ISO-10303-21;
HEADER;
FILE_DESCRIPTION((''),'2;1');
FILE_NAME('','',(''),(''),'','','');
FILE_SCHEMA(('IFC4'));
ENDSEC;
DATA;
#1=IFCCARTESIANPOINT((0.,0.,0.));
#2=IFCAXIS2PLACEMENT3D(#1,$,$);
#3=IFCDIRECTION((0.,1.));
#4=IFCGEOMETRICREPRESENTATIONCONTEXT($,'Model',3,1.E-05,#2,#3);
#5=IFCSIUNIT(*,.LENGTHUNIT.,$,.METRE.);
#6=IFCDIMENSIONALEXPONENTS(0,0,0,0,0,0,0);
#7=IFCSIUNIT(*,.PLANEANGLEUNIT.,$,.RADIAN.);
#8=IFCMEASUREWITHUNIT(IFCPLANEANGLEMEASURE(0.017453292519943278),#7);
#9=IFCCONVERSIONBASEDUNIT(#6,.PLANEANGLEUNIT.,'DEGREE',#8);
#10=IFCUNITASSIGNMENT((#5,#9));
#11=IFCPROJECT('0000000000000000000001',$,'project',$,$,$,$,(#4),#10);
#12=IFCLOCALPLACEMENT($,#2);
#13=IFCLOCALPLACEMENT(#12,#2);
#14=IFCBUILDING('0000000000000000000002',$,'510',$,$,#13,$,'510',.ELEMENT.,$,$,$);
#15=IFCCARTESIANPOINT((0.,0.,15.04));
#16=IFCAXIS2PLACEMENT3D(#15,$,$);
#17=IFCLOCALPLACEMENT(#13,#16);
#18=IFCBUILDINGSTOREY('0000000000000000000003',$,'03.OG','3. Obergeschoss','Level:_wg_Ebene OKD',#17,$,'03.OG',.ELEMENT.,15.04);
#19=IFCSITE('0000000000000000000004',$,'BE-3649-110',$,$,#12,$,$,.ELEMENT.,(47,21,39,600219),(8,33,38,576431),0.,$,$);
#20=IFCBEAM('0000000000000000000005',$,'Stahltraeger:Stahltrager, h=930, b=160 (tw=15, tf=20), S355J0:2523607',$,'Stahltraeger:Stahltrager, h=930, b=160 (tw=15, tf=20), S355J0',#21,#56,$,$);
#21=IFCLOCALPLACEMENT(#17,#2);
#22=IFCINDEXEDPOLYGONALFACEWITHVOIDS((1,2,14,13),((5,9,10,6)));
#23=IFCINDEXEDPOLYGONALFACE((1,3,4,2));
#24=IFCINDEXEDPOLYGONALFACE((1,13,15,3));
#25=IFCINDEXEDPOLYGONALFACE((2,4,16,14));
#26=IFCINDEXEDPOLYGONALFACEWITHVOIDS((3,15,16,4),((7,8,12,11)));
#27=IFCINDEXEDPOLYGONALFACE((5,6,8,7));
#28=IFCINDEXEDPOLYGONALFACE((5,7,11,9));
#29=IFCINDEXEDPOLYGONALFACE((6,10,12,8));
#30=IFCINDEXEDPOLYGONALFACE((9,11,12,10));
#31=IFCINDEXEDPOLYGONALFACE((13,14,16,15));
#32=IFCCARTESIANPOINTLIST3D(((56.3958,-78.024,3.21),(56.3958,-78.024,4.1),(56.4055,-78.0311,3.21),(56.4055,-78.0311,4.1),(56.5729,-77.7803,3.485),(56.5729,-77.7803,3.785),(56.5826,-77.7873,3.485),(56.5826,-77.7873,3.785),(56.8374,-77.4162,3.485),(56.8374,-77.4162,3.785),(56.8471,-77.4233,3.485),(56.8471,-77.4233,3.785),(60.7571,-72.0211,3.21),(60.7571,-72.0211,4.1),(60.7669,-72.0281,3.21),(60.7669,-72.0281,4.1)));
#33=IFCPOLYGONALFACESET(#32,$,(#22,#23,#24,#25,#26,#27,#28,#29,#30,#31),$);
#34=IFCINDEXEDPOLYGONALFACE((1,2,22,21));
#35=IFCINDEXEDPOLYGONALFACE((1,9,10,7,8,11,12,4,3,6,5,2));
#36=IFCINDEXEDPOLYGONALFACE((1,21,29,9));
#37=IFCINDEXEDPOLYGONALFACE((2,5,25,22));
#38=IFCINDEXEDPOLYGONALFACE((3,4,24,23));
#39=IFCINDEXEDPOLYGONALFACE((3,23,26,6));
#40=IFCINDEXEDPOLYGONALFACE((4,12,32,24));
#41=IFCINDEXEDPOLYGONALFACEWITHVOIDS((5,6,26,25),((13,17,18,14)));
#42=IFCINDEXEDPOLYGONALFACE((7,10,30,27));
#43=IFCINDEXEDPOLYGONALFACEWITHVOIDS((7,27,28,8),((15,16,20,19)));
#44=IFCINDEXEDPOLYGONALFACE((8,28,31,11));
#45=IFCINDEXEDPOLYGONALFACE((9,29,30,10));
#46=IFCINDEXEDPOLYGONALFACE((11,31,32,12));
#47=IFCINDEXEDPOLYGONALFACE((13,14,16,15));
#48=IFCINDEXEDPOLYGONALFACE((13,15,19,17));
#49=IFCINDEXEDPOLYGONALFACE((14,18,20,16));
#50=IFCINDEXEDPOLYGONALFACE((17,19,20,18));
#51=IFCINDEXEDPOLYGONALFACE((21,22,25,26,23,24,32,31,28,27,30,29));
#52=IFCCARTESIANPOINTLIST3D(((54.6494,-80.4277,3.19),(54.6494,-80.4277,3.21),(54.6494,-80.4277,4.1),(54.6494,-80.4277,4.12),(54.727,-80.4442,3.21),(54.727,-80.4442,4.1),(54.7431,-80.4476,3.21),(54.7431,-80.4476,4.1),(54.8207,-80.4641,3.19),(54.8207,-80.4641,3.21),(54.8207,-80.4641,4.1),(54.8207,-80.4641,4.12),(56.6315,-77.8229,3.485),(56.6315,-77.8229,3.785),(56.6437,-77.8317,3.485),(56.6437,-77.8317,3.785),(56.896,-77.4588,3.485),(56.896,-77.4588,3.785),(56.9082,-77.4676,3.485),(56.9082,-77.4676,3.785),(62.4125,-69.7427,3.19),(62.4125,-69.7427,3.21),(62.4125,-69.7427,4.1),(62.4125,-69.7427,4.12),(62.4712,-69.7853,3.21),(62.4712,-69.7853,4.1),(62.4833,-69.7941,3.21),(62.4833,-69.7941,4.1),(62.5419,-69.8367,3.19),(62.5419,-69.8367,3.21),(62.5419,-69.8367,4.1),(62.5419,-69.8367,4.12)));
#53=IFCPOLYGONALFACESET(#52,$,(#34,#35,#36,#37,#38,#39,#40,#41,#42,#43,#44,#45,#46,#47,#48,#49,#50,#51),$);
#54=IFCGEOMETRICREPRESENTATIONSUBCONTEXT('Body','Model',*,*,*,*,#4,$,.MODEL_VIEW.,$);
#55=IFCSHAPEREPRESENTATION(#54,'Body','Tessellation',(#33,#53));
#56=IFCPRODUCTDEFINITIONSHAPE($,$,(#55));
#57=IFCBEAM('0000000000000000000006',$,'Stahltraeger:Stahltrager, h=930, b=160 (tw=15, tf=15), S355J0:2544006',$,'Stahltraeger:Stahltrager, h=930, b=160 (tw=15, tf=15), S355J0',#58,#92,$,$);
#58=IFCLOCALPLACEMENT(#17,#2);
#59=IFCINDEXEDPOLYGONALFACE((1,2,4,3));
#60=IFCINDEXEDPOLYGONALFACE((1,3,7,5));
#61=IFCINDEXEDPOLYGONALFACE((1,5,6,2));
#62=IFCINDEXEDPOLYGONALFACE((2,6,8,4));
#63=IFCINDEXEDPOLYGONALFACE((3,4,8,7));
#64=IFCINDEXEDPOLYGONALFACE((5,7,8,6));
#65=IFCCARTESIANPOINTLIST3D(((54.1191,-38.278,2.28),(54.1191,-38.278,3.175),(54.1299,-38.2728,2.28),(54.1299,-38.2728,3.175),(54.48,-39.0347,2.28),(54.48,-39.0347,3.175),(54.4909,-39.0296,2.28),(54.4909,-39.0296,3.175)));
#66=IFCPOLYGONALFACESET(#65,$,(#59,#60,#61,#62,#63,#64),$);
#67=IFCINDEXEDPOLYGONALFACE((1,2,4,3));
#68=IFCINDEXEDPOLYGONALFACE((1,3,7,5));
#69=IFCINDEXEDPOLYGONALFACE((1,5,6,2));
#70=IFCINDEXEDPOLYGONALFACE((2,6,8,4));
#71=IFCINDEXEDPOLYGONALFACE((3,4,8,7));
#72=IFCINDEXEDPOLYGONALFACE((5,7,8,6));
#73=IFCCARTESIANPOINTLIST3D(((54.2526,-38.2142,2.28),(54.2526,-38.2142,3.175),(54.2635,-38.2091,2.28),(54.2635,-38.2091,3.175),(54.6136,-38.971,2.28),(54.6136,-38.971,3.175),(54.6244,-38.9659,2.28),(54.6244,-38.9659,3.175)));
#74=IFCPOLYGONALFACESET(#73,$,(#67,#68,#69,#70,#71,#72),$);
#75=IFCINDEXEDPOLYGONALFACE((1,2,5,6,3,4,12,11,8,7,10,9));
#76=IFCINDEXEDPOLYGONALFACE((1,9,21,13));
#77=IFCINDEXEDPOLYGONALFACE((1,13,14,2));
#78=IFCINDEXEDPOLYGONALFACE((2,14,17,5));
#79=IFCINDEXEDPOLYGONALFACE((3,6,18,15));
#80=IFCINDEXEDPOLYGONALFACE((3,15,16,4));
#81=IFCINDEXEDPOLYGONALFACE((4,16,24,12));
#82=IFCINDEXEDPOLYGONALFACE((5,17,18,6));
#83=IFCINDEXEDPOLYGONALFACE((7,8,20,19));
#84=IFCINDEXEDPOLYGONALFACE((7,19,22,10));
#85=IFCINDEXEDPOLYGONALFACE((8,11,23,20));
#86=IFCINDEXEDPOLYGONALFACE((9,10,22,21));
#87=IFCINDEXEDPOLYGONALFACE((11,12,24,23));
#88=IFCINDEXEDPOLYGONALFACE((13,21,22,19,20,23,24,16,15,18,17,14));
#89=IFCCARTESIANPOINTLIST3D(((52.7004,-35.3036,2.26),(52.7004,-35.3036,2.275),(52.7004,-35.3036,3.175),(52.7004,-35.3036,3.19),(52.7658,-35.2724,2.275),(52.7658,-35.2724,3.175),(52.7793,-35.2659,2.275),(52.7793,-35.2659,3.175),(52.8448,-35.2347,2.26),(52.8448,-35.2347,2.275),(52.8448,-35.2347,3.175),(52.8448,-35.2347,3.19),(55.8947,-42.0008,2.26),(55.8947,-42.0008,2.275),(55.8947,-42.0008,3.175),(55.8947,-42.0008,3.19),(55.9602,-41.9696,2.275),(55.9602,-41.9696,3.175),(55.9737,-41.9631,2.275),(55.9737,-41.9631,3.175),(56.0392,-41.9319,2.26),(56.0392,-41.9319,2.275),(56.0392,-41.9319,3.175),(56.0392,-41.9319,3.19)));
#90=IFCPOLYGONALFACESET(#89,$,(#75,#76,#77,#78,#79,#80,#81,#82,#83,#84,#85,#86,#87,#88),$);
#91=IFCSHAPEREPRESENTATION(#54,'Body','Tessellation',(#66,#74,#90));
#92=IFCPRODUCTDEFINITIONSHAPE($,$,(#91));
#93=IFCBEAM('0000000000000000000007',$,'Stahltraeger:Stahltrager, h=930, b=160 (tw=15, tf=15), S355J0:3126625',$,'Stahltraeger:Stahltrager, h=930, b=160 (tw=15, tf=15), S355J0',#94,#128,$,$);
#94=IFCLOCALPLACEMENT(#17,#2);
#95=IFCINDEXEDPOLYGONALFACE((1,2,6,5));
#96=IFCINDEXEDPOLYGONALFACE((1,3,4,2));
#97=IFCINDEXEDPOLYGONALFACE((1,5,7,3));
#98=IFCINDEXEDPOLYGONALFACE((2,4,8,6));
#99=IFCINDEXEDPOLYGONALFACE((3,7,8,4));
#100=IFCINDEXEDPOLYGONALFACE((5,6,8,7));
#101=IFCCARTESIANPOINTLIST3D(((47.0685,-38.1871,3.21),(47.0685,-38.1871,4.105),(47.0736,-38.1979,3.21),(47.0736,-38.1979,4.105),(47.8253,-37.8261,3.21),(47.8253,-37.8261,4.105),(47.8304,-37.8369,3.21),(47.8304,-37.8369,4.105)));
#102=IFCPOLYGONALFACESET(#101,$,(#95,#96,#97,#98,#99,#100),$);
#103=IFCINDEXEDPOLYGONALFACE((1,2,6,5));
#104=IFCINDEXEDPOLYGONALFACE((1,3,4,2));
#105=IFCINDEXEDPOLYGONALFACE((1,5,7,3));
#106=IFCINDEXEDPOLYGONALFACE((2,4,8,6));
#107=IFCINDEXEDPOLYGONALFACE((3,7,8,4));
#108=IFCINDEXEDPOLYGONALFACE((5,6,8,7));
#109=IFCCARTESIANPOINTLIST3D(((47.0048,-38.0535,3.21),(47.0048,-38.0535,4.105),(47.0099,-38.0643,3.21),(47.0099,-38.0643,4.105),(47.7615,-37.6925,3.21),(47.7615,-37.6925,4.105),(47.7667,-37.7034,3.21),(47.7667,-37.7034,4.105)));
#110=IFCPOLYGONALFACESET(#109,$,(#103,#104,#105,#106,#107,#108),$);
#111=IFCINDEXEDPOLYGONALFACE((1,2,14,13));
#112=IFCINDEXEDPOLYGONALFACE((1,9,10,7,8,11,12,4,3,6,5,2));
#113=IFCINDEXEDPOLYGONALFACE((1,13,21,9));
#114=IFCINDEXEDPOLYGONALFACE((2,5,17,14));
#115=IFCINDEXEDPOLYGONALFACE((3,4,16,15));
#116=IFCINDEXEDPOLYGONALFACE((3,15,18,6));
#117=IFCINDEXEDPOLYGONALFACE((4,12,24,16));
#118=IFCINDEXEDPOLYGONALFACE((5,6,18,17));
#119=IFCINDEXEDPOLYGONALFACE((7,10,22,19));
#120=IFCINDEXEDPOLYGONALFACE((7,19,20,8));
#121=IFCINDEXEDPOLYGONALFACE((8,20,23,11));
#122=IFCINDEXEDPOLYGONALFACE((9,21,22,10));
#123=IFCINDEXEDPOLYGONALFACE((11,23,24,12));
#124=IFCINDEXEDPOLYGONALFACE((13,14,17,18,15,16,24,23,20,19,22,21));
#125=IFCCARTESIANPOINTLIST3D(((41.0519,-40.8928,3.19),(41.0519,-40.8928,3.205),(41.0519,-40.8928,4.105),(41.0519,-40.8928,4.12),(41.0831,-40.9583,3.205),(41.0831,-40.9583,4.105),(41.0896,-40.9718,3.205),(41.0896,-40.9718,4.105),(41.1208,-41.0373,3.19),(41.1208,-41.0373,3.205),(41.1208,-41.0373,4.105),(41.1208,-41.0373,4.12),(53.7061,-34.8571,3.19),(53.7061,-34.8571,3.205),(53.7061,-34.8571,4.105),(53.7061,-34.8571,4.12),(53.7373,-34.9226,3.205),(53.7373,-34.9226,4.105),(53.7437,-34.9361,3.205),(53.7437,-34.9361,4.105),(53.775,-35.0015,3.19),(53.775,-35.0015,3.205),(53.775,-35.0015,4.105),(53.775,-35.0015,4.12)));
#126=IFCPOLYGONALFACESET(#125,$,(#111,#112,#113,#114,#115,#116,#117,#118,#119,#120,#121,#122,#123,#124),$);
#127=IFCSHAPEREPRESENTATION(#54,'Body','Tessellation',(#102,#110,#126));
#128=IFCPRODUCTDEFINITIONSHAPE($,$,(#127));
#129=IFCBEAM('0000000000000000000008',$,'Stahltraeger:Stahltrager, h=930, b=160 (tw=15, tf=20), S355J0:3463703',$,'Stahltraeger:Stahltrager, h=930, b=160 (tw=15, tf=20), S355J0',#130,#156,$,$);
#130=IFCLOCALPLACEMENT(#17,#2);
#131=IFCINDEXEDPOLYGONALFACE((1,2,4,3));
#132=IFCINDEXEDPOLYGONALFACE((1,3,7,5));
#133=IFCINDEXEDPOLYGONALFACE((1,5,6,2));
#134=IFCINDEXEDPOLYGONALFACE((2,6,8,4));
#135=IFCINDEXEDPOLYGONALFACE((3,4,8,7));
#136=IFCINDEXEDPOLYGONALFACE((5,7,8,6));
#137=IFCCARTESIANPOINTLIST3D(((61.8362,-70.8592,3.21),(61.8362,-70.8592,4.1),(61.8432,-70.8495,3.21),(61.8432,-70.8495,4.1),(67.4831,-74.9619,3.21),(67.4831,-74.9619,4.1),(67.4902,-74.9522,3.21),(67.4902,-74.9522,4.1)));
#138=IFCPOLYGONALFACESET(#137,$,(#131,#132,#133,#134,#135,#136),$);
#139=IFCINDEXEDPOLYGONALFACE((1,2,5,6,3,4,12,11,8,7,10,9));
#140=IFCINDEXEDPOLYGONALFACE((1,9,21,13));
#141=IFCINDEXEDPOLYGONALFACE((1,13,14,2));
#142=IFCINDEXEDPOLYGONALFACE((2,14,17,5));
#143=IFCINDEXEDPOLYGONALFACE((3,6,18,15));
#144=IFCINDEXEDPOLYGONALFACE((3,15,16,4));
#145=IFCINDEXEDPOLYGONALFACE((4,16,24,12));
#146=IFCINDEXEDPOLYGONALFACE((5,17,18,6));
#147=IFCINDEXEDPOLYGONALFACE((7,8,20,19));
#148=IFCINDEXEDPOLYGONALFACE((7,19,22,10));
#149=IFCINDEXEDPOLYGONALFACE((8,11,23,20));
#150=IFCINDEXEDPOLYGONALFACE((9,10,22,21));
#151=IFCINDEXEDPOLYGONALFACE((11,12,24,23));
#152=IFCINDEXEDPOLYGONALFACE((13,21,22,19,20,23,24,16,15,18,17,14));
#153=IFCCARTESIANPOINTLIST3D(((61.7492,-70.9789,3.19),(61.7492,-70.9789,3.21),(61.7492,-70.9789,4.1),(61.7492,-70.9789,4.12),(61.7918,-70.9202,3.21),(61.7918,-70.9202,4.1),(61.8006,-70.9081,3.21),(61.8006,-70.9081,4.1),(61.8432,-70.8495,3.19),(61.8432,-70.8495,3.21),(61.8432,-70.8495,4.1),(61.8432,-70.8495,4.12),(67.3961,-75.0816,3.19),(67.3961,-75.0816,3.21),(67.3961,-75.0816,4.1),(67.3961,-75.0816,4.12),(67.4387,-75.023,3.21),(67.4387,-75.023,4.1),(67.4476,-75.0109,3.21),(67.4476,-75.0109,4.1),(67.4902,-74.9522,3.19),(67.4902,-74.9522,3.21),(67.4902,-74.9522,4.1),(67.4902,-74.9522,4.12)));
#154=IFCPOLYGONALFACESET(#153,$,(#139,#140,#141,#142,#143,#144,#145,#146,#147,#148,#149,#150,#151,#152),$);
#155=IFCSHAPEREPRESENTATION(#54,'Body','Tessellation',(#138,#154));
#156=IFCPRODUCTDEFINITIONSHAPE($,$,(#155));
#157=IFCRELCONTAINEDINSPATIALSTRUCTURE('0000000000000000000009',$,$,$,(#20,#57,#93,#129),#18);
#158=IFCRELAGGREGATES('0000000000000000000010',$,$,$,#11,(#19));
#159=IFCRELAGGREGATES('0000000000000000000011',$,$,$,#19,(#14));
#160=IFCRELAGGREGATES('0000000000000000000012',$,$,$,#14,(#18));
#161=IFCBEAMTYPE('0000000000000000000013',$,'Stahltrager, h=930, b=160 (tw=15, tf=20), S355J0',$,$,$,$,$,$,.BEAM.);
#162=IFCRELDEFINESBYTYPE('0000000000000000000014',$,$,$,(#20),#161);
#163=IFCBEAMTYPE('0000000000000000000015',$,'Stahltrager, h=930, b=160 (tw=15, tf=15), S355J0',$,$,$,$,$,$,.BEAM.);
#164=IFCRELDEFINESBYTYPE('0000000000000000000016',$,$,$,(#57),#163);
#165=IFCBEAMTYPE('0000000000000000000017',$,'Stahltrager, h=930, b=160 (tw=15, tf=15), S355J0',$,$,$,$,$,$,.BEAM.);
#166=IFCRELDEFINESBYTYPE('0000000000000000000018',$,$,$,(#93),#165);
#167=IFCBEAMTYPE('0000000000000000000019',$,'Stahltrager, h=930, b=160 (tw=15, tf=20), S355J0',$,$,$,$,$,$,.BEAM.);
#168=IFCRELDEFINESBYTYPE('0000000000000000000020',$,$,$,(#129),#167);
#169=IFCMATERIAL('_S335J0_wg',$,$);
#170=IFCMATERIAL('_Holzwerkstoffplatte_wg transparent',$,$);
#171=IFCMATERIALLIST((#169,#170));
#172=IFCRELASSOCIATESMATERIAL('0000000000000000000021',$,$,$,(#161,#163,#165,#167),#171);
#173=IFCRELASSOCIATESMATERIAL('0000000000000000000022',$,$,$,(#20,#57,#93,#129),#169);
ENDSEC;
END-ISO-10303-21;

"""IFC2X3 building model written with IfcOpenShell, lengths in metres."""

from ifc_helpers import new_model, entity, si_unit, converted_unit, direction, frame, frame_2d, origin, place, context, subcontext, project, spatial, polyline, rectangle, i_section, outline, extrude, boolean, clip, halfspace, source, transform, mapped, material, material_list, type_object, type_shapes, element, save


model = new_model("IFC2X3")

# Units and contexts
model_context = context("Model", 3, precision=1e-05, world=origin(), true_north=direction((0.0, 1.0)))
body_context = subcontext(model_context, "Body", "Model", "MODEL_VIEW")
ifc_project = project(units=[si_unit("LENGTHUNIT", "METRE"), converted_unit("PLANEANGLEUNIT", "DEGREE", entity("IfcPlaneAngleMeasure", 0.017453292519943278), si_unit("PLANEANGLEUNIT", "RADIAN"), dimensions=[0, 0, 0, 0, 0, 0, 0])], contexts=[model_context])

# Site, building, storey
site_placement = place(None, origin())
site = spatial("IfcSite", under=ifc_project, at=site_placement, Name="BE-3649-110", CompositionType="ELEMENT", RefLatitude=(47, 21, 39, 600219), RefLongitude=(8, 33, 38, 576431), RefElevation=0.0)
building_placement = place(site_placement, origin())
building = spatial("IfcBuilding", under=site, at=building_placement, Name="510", LongName="510", CompositionType="ELEMENT")
storey_placement = place(building_placement, frame((0.0, 0.0, 15.04)))
storey = spatial("IfcBuildingStorey", under=building, at=storey_placement, Name="03.OG", Description="3. Obergeschoss", ObjectType="Level:_wg_Ebene OKD", LongName="03.OG", CompositionType="ELEMENT", Elevation=15.04)

# Beams
ifc_material_1 = material(Name="_S335J0_wg")
ifc_material_2 = material(Name="_Holzwerkstoffplatte_wg transparent")
ifc_material_list = material_list([ifc_material_1, ifc_material_2])
beam_type_1 = type_object("IfcBeamType", Name="Stahltrager, h=930, b=160 (tw=15, tf=20), S355J0", PredefinedType="BEAM", material=ifc_material_list)
shared_shape_1 = source(origin(), body_context, "Body", "SweptSolid", [
    boolean("DIFFERENCE", extrude(rectangle(XDim=0.89, YDim=0.012, at=frame_2d((0.0, 0.0), x_axis=(0.0, 1.0))), frame((60.762, -72.0246, 18.695), z_axis=(-0.587785, -0.809017, 0.0), x_axis=(0.809017, -0.587785, 0.0)), (0.0, 0.0, 1.0), 7.42), extrude(rectangle(XDim=0.3, YDim=0.45, at=frame_2d((0.0, 0.0), x_axis=(0.0, 1.0))), frame((56.7148, -77.6053, 18.675), z_axis=(-0.809017, 0.587785, 0.0), x_axis=(0.587785, 0.809017, 0.0)), (0.0, 0.0, 1.0), 0.012)),
    boolean("DIFFERENCE", clip(extrude(i_section(OverallWidth=0.16, OverallDepth=0.93, WebThickness=0.015, FlangeThickness=0.02, at=frame_2d((0.0, 0.0), x_axis=(0.0, 1.0))), frame((62.4772, -69.7897, 18.695), z_axis=(-0.587785, -0.809017, 0.0), x_axis=(0.0, 0.0, -1.0)), (0.0, 0.0, 1.0), 13.2074), halfspace(frame((55.5168, -80.6121, -0.22), z_axis=(-0.207912, -0.978148, 0.0), x_axis=(-0.978148, 0.207912, 0.0)), False)), extrude(rectangle(XDim=0.3, YDim=0.45, at=frame_2d((0.0, 0.0), x_axis=(0.0, 1.0))), frame((56.7759, -77.6497, 18.675), z_axis=(-0.809017, 0.587785, 0.0), x_axis=(0.587785, 0.809017, 0.0)), (0.0, 0.0, 1.0), 0.015)),
])
type_shapes(beam_type_1, [shared_shape_1])
beam_1_placement = place(storey_placement, frame((0.0, 0.0, -15.04)))
element("IfcBeam", 1, at=beam_1_placement, inside=storey, type_object=beam_type_1, material=ifc_material_1, Name="Stahltraeger:Stahltrager, h=930, b=160 (tw=15, tf=20), S355J0:2523607", ObjectType="Stahltraeger:Stahltrager, h=930, b=160 (tw=15, tf=20), S355J0", context=body_context, shape_type="MappedRepresentation", body=[
    mapped(shared_shape_1, transform((0.0, 0.0, 0.0), scale=1.0)),
])
beam_type_2 = type_object("IfcBeamType", Name="Stahltrager, h=930, b=160 (tw=15, tf=15), S355J0", PredefinedType="BEAM", material=ifc_material_list)
shared_shape_2 = source(origin(), body_context, "Body", "SweptSolid", [
    extrude(rectangle(XDim=0.895, YDim=0.012, at=frame_2d((0.0, 0.0), x_axis=(1.0, 0.0))), frame((54.1245, -38.2754, 17.7675), z_axis=(0.430511, -0.902585, 0.0), x_axis=(0.0, 0.0, -1.0)), (0.0, 0.0, 1.0), 0.8385),
    extrude(rectangle(XDim=0.895, YDim=0.012, at=frame_2d((0.0, 0.0), x_axis=(1.0, 0.0))), frame((54.2581, -38.2117, 17.7675), z_axis=(0.430511, -0.902585, 0.0), x_axis=(0.0, 0.0, -1.0)), (0.0, 0.0, 1.0), 0.8385),
    extrude(i_section(OverallWidth=0.16, OverallDepth=0.93, WebThickness=0.015, FlangeThickness=0.015, at=frame_2d((0.0, 0.0), x_axis=(0.0, 1.0))), frame((52.7726, -35.2691, 17.765), z_axis=(0.430511, -0.902585, 0.0), x_axis=(0.0, 0.0, -1.0)), (0.0, 0.0, 1.0), 7.42),
])
type_shapes(beam_type_2, [shared_shape_2])
beam_2_placement = place(storey_placement, frame((0.0, 0.0, -15.04)))
element("IfcBeam", 2, at=beam_2_placement, inside=storey, type_object=beam_type_2, material=ifc_material_1, Name="Stahltraeger:Stahltrager, h=930, b=160 (tw=15, tf=15), S355J0:2544006", ObjectType="Stahltraeger:Stahltrager, h=930, b=160 (tw=15, tf=15), S355J0", context=body_context, shape_type="MappedRepresentation", body=[
    mapped(shared_shape_2, transform((0.0, 0.0, 0.0), scale=1.0)),
])
beam_type_3 = type_object("IfcBeamType", Name="Stahltrager, h=930, b=160 (tw=15, tf=15), S355J0", PredefinedType="BEAM", material=ifc_material_list)
shared_shape_3 = source(origin(), body_context, "Body", "SweptSolid", [
    extrude(rectangle(XDim=0.895, YDim=0.012, at=frame_2d((0.0, 0.0), x_axis=(1.0, 0.0))), frame((47.0711, -38.1925, 18.6975), z_axis=(0.902585, 0.430511, 0.0), x_axis=(0.0, 0.0, 1.0)), (0.0, 0.0, 1.0), 0.8385),
    extrude(rectangle(XDim=0.895, YDim=0.012, at=frame_2d((0.0, 0.0), x_axis=(1.0, 0.0))), frame((47.0073, -38.0589, 18.6975), z_axis=(0.902585, 0.430511, 0.0), x_axis=(0.0, 0.0, 1.0)), (0.0, 0.0, 1.0), 0.8385),
    extrude(outline(polyline([(0.45, -0.08), (0.465, -0.08), (0.465, 0.08), (0.45, 0.08), (0.45, 0.0075), (-0.45, 0.0075), (-0.45, 0.08), (-0.465, 0.08), (-0.465, -0.08), (-0.45, -0.08), (-0.45, -0.0075), (0.45, -0.0075), (0.45, -0.08)])), frame((41.0864, -40.9651, 18.695), z_axis=(0.902585, 0.430511, 0.0), x_axis=(0.0, 0.0, 1.0)), (0.0, 0.0, 1.0), 14.0199),
])
type_shapes(beam_type_3, [shared_shape_3])
beam_3_placement = place(storey_placement, frame((0.0, 0.0, -15.04)))
element("IfcBeam", 3, at=beam_3_placement, inside=storey, type_object=beam_type_3, material=ifc_material_1, Name="Stahltraeger:Stahltrager, h=930, b=160 (tw=15, tf=15), S355J0:3126625", ObjectType="Stahltraeger:Stahltrager, h=930, b=160 (tw=15, tf=15), S355J0", context=body_context, shape_type="MappedRepresentation", body=[
    mapped(shared_shape_3, transform((0.0, 0.0, 0.0), scale=1.0)),
])
beam_type_4 = type_object("IfcBeamType", Name="Stahltrager, h=930, b=160 (tw=15, tf=20), S355J0", PredefinedType="BEAM", material=ifc_material_list)
shared_shape_4 = source(origin(), body_context, "Body", "SweptSolid", [
    extrude(rectangle(XDim=0.89, YDim=0.012, at=frame_2d((0.0, 0.0), x_axis=(1.0, 0.0))), frame((61.8397, -70.8543, 18.695), z_axis=(0.809017, -0.587785, 0.0), x_axis=(0.0, 0.0, -1.0)), (0.0, 0.0, 1.0), 6.98),
    extrude(i_section(OverallWidth=0.16, OverallDepth=0.93, WebThickness=0.015, FlangeThickness=0.02, at=frame_2d((0.0, 0.0), x_axis=(0.0, 1.0))), frame((61.7962, -70.9142, 18.695), z_axis=(0.809017, -0.587785, 0.0), x_axis=(0.0, 0.0, -1.0)), (0.0, 0.0, 1.0), 6.98),
])
type_shapes(beam_type_4, [shared_shape_4])
beam_4_placement = place(storey_placement, frame((0.0, 0.0, -15.04)))
element("IfcBeam", 4, at=beam_4_placement, inside=storey, type_object=beam_type_4, material=ifc_material_1, Name="Stahltraeger:Stahltrager, h=930, b=160 (tw=15, tf=20), S355J0:3463703", ObjectType="Stahltraeger:Stahltrager, h=930, b=160 (tw=15, tf=20), S355J0", context=body_context, shape_type="MappedRepresentation", body=[
    mapped(shared_shape_4, transform((0.0, 0.0, 0.0), scale=1.0)),
])

save(model, "model.ifc")
